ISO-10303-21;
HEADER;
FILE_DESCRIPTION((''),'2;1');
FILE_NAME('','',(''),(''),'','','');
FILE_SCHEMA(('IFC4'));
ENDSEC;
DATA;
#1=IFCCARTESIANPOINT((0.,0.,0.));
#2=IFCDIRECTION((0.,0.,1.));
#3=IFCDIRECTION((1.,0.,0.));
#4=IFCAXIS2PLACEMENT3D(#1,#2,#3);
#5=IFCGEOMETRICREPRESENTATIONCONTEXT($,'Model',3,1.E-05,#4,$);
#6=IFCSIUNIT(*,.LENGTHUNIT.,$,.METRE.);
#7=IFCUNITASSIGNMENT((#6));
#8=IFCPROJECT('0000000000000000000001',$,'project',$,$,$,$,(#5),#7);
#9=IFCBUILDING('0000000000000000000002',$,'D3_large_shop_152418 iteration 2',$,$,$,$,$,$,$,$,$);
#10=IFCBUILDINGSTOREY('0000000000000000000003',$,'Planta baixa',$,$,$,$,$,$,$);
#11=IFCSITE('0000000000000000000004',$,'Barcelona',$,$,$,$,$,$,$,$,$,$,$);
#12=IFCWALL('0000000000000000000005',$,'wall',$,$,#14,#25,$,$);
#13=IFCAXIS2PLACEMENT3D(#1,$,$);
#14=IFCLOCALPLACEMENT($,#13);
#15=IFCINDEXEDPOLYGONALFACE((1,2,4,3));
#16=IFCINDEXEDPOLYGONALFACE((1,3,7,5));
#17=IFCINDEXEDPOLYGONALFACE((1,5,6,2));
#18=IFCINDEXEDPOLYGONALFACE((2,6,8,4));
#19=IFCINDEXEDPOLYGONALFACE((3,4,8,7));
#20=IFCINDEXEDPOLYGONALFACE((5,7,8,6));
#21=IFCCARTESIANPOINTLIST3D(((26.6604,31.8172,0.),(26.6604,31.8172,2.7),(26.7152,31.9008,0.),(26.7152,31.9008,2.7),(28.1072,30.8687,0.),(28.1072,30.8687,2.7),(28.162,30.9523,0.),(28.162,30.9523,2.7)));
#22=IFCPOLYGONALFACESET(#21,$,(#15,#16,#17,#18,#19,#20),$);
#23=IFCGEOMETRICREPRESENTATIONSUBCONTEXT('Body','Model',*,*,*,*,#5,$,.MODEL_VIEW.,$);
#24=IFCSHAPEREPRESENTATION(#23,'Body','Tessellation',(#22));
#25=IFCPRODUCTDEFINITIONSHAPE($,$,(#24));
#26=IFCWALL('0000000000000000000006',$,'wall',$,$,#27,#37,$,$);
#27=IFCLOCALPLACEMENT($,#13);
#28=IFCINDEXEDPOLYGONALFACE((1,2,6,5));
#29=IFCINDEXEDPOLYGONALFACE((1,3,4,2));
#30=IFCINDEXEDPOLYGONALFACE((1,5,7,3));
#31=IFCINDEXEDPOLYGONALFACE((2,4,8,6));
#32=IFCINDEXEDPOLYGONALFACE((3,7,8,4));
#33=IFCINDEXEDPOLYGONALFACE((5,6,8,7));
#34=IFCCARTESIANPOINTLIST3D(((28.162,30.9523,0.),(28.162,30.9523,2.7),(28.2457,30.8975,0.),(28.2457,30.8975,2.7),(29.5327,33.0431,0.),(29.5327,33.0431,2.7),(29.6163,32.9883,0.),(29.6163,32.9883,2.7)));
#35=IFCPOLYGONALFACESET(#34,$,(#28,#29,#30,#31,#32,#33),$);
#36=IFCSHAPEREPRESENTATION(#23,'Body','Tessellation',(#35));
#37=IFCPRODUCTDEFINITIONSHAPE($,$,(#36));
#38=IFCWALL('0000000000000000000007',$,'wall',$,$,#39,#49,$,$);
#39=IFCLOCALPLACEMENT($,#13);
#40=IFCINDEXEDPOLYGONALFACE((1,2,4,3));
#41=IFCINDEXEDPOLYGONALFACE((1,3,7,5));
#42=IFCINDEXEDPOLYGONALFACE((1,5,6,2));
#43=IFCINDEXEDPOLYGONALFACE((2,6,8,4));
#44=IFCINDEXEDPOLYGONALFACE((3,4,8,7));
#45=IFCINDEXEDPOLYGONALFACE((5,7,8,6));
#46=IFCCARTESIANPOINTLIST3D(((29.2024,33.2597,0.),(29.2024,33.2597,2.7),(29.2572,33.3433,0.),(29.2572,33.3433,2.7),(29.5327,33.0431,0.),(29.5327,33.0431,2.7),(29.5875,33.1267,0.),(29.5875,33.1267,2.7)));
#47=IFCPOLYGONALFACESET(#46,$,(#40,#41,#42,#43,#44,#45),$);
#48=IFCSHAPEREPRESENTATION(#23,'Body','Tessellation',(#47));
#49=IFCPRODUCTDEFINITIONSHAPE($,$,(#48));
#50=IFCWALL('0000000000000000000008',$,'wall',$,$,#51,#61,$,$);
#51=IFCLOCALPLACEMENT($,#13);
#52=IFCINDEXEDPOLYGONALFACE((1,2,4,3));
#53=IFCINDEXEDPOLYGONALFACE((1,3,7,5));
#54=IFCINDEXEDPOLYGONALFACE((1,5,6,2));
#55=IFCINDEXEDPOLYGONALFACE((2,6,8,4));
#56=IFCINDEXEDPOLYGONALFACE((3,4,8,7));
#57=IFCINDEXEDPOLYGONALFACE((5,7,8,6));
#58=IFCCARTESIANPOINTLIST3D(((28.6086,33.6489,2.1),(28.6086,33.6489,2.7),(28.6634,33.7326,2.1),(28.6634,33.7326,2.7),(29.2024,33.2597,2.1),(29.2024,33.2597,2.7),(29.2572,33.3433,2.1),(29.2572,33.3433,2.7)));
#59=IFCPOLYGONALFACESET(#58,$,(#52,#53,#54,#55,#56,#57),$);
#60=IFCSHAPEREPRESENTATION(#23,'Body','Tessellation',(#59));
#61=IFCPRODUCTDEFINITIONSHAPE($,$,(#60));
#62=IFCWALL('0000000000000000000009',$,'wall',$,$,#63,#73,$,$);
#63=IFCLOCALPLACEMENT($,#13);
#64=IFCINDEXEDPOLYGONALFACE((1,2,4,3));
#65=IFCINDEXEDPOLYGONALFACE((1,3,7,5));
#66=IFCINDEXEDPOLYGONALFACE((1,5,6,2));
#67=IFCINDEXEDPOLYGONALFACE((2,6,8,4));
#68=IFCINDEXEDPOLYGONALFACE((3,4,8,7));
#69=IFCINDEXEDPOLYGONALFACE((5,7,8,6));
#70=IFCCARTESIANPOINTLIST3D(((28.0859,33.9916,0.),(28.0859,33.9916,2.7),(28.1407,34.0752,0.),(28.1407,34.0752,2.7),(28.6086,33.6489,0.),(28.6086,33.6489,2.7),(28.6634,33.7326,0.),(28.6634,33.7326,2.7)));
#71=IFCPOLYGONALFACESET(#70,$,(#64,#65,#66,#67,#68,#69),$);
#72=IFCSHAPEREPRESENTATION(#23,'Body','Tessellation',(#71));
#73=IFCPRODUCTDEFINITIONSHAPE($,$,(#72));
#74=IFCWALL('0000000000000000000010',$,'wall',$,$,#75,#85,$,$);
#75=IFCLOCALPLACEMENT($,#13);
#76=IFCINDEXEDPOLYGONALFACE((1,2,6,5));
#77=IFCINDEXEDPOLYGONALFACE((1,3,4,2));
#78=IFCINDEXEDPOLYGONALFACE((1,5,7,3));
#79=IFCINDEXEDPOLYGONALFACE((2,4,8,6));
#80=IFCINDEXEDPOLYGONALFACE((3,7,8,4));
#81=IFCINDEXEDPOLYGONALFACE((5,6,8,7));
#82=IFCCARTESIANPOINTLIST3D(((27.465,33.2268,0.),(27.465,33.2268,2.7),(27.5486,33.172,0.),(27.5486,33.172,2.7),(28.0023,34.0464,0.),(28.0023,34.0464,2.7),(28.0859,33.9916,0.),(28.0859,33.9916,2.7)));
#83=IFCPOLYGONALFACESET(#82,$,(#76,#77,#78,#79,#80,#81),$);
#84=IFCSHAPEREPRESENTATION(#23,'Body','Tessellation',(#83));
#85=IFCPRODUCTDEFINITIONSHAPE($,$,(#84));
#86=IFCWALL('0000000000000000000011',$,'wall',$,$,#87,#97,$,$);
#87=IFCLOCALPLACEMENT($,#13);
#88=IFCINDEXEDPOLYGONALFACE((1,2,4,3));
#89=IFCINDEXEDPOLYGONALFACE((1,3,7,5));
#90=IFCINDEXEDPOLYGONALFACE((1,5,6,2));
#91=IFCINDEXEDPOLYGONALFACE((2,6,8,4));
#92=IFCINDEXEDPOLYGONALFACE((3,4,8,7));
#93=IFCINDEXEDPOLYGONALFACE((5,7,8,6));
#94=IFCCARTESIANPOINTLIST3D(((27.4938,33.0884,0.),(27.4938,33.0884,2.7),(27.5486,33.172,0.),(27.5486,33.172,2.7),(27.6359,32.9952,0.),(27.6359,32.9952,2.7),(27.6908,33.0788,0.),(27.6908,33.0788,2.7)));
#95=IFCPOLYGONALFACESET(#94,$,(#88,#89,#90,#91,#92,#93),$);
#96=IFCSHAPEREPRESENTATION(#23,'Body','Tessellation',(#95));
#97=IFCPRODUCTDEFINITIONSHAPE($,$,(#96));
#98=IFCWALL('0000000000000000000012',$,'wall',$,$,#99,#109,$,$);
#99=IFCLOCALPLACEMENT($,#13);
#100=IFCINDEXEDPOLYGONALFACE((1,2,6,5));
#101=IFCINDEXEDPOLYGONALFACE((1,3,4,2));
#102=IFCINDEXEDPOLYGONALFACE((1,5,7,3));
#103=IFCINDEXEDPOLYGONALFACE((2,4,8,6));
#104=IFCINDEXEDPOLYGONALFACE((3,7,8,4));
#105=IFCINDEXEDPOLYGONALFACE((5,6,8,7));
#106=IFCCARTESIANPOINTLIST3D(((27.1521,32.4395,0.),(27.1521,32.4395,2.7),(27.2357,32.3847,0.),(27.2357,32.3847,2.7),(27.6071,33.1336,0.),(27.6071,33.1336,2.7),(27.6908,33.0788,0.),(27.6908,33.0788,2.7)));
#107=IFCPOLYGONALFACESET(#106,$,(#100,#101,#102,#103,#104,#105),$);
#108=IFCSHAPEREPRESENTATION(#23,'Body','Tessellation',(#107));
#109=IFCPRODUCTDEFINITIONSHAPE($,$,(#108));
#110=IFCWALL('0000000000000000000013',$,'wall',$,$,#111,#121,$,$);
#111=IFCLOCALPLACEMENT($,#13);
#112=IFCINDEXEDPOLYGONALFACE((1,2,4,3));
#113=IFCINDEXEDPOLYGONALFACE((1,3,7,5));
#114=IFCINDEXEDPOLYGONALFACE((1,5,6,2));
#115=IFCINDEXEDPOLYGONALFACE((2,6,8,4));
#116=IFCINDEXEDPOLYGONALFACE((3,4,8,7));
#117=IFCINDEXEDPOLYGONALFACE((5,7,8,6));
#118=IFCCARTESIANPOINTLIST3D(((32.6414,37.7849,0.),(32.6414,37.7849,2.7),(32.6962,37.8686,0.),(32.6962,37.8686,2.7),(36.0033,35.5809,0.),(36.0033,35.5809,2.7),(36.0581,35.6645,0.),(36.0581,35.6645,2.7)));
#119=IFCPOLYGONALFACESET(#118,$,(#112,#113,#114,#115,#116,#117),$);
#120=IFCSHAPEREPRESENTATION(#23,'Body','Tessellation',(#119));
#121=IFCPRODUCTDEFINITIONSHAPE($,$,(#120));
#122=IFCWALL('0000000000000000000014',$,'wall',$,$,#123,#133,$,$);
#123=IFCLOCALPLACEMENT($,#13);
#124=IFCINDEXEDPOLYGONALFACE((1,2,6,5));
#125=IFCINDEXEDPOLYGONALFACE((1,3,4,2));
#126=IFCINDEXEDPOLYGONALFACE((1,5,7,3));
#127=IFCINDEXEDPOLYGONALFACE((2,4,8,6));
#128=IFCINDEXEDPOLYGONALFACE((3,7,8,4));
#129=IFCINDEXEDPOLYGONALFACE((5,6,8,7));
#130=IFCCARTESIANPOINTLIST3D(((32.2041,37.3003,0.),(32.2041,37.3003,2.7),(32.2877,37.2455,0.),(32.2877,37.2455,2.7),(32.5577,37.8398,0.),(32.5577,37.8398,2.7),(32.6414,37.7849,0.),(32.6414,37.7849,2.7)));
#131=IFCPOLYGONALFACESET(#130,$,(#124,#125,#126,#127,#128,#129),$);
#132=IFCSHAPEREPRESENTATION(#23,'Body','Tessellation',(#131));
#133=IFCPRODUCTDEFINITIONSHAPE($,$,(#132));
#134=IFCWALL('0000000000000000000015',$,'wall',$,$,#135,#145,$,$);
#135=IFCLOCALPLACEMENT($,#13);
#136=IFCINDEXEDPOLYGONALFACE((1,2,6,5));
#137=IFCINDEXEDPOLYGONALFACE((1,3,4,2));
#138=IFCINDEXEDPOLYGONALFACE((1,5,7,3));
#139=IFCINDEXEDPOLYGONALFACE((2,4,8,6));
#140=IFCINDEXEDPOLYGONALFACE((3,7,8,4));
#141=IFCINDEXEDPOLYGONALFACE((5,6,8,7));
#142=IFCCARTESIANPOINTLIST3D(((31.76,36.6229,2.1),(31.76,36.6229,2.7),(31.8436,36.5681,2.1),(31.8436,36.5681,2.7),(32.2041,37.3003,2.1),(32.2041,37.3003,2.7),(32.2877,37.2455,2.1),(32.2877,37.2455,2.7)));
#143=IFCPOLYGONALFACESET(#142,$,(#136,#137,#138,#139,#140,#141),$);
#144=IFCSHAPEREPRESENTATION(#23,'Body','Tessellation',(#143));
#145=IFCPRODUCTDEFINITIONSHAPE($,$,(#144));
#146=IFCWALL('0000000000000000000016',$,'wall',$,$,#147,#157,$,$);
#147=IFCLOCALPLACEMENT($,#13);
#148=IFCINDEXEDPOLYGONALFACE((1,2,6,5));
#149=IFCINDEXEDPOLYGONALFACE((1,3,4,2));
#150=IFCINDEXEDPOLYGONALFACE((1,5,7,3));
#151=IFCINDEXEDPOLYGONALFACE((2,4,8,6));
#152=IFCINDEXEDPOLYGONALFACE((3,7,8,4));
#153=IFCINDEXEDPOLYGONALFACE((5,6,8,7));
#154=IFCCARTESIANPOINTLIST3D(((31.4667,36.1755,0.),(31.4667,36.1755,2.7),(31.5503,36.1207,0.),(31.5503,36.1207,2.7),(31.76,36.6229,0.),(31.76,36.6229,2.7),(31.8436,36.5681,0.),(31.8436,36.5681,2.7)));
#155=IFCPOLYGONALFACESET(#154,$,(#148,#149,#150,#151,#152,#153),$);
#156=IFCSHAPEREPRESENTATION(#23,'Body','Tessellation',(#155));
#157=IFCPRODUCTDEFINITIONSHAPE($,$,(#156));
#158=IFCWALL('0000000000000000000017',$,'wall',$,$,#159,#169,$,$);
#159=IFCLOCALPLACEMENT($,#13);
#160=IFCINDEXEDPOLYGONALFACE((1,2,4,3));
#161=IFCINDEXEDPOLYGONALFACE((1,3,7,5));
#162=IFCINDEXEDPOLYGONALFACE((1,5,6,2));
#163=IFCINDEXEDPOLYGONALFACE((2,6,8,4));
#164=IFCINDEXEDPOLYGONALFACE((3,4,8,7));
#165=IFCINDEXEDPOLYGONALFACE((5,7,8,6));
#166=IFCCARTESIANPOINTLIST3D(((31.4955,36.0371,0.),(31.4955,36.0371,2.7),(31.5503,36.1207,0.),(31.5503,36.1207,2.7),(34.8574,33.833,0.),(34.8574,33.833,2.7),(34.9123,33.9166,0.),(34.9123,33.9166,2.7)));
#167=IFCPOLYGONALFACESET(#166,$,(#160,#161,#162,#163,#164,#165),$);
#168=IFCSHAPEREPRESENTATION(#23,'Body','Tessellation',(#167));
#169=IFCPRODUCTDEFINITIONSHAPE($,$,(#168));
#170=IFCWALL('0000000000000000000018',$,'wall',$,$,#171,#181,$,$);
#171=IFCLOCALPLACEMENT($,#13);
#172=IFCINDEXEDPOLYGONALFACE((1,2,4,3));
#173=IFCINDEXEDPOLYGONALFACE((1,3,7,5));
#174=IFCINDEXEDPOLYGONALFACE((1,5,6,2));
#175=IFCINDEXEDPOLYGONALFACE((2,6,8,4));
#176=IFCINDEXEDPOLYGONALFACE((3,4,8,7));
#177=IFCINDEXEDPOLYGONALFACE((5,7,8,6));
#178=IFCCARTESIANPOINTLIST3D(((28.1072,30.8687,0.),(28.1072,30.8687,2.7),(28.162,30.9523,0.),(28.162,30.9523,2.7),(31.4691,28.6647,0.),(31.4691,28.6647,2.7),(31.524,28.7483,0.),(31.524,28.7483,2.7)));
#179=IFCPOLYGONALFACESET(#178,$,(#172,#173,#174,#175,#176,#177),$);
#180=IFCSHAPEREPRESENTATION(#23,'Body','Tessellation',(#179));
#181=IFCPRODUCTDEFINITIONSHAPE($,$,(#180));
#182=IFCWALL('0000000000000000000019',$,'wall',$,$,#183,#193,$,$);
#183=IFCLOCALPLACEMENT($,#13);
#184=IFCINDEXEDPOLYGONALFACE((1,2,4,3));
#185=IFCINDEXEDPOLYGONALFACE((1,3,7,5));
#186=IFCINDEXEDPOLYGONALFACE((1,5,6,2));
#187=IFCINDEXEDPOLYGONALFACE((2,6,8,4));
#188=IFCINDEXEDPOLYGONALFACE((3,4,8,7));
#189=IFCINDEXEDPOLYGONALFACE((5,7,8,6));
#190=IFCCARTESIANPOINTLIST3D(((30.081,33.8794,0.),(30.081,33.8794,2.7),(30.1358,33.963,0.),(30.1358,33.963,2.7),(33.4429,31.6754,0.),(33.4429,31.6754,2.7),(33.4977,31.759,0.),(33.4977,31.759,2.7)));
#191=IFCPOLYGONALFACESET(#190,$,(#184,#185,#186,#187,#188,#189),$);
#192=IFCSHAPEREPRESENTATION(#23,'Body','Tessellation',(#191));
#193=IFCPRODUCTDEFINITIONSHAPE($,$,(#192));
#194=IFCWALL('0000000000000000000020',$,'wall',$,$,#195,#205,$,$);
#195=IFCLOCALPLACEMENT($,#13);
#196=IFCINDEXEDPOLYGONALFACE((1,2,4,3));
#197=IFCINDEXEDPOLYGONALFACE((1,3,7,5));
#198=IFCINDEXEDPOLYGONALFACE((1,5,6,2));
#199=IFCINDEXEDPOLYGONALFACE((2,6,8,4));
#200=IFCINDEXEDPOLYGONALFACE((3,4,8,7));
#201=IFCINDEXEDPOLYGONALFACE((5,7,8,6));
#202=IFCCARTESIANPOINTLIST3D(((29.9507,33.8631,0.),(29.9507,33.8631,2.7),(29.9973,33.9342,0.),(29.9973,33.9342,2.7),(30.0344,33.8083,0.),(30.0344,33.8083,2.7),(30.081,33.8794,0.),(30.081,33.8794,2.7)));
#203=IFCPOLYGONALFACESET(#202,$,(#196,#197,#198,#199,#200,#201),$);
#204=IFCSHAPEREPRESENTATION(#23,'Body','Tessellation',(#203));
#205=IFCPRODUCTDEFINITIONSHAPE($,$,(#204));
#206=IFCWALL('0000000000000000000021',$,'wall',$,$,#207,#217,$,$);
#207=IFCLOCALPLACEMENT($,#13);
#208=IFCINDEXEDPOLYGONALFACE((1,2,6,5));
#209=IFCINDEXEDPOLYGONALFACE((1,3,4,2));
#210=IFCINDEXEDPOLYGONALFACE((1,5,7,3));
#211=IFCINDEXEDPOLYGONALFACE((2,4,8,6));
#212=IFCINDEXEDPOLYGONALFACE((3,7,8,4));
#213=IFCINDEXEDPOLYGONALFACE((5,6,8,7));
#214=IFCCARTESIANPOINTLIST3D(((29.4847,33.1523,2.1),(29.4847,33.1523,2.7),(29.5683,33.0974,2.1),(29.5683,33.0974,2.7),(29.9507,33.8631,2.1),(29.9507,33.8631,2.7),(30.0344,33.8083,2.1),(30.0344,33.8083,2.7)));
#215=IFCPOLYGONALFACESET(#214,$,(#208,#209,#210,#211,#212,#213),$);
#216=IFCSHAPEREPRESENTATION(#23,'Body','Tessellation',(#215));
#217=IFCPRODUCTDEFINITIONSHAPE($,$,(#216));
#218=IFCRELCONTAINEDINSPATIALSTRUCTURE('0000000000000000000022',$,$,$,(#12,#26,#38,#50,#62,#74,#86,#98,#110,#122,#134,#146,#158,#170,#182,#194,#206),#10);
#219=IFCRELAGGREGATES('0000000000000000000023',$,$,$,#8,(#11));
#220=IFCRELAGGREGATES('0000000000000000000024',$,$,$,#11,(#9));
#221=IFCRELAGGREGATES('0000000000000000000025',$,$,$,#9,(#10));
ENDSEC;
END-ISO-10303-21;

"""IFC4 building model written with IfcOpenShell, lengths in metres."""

from ifc_helpers import new_model, si_unit, frame, origin, origin_with_axes, place, context, subcontext, project, spatial, polyline, outline, extrude, element, save


model = new_model("IFC4")

# Units and contexts
model_context = context("Model", 3, precision=1e-05, world=origin_with_axes())
body_context = subcontext(model_context, "Body", "Model", "MODEL_VIEW")
ifc_project = project(units=[si_unit("LENGTHUNIT", "METRE")], contexts=[model_context])

# Site, building, storey
site = spatial("IfcSite", under=ifc_project, Name="Barcelona")
building = spatial("IfcBuilding", under=site, Name="D3_large_shop_152418 iteration 2")
storey = spatial("IfcBuildingStorey", under=building, Name="Planta baixa")

# Walls
wall_1_placement = place(None, origin_with_axes())
element("IfcWall", 1, at=wall_1_placement, inside=storey, Name="wall", context=body_context, shape_type="SweptSolid", body=[
    extrude(outline(polyline([(26.7152, 31.9008), (28.162, 30.9523), (28.1072, 30.8687), (26.6604, 31.8172), (26.7152, 31.9008)])), origin(), (0.0, 0.0, 1.0), 2.7),
])
wall_2_placement = place(None, origin_with_axes())
element("IfcWall", 2, at=wall_2_placement, inside=storey, Name="wall", context=body_context, shape_type="SweptSolid", body=[
    extrude(outline(polyline([(28.162, 30.9523), (29.5327, 33.0431), (29.6163, 32.9883), (28.2457, 30.8975), (28.162, 30.9523)])), origin(), (0.0, 0.0, 1.0), 2.7),
])
wall_3_placement = place(None, origin_with_axes())
element("IfcWall", 3, at=wall_3_placement, inside=storey, Name="wall", context=body_context, shape_type="SweptSolid", body=[
    extrude(outline(polyline([(29.5327, 33.0431), (29.2024, 33.2597), (29.2572, 33.3433), (29.5875, 33.1267), (29.5327, 33.0431)])), origin(), (0.0, 0.0, 1.0), 2.7),
])
wall_4_placement = place(None, origin_with_axes())
element("IfcWall", 4, at=wall_4_placement, inside=storey, Name="wall", context=body_context, shape_type="SweptSolid", body=[
    extrude(outline(polyline([(29.2024, 33.2597), (28.6086, 33.6489), (28.6634, 33.7326), (29.2572, 33.3433), (29.2024, 33.2597)])), frame((0.0, 0.0, 2.1)), (0.0, 0.0, 1.0), 0.6),
])
wall_5_placement = place(None, origin_with_axes())
element("IfcWall", 5, at=wall_5_placement, inside=storey, Name="wall", context=body_context, shape_type="SweptSolid", body=[
    extrude(outline(polyline([(28.6086, 33.6489), (28.0859, 33.9916), (28.1407, 34.0752), (28.6634, 33.7326), (28.6086, 33.6489)])), origin(), (0.0, 0.0, 1.0), 2.7),
])
wall_6_placement = place(None, origin_with_axes())
element("IfcWall", 6, at=wall_6_placement, inside=storey, Name="wall", context=body_context, shape_type="SweptSolid", body=[
    extrude(outline(polyline([(28.0859, 33.9916), (27.5486, 33.172), (27.465, 33.2268), (28.0023, 34.0464), (28.0859, 33.9916)])), origin(), (0.0, 0.0, 1.0), 2.7),
])
wall_7_placement = place(None, origin_with_axes())
element("IfcWall", 7, at=wall_7_placement, inside=storey, Name="wall", context=body_context, shape_type="SweptSolid", body=[
    extrude(outline(polyline([(27.5486, 33.172), (27.6908, 33.0788), (27.6359, 32.9952), (27.4938, 33.0884), (27.5486, 33.172)])), origin(), (0.0, 0.0, 1.0), 2.7),
])
wall_8_placement = place(None, origin_with_axes())
element("IfcWall", 8, at=wall_8_placement, inside=storey, Name="wall", context=body_context, shape_type="SweptSolid", body=[
    extrude(outline(polyline([(27.6908, 33.0788), (27.2357, 32.3847), (27.1521, 32.4395), (27.6071, 33.1336), (27.6908, 33.0788)])), origin(), (0.0, 0.0, 1.0), 2.7),
])
wall_9_placement = place(None, origin_with_axes())
element("IfcWall", 9, at=wall_9_placement, inside=storey, Name="wall", context=body_context, shape_type="SweptSolid", body=[
    extrude(outline(polyline([(36.0033, 35.5809), (32.6414, 37.7849), (32.6962, 37.8686), (36.0581, 35.6645), (36.0033, 35.5809)])), origin(), (0.0, 0.0, 1.0), 2.7),
])
wall_10_placement = place(None, origin_with_axes())
element("IfcWall", 10, at=wall_10_placement, inside=storey, Name="wall", context=body_context, shape_type="SweptSolid", body=[
    extrude(outline(polyline([(32.6414, 37.7849), (32.2877, 37.2455), (32.2041, 37.3003), (32.5577, 37.8398), (32.6414, 37.7849)])), origin(), (0.0, 0.0, 1.0), 2.7),
])
wall_11_placement = place(None, origin_with_axes())
element("IfcWall", 11, at=wall_11_placement, inside=storey, Name="wall", context=body_context, shape_type="SweptSolid", body=[
    extrude(outline(polyline([(32.2877, 37.2455), (31.8436, 36.5681), (31.76, 36.6229), (32.2041, 37.3003), (32.2877, 37.2455)])), frame((0.0, 0.0, 2.1)), (0.0, 0.0, 1.0), 0.6),
])
wall_12_placement = place(None, origin_with_axes())
element("IfcWall", 12, at=wall_12_placement, inside=storey, Name="wall", context=body_context, shape_type="SweptSolid", body=[
    extrude(outline(polyline([(31.8436, 36.5681), (31.5503, 36.1207), (31.4667, 36.1755), (31.76, 36.6229), (31.8436, 36.5681)])), origin(), (0.0, 0.0, 1.0), 2.7),
])
wall_13_placement = place(None, origin_with_axes())
element("IfcWall", 13, at=wall_13_placement, inside=storey, Name="wall", context=body_context, shape_type="SweptSolid", body=[
    extrude(outline(polyline([(31.5503, 36.1207), (34.9123, 33.9166), (34.8574, 33.833), (31.4955, 36.0371), (31.5503, 36.1207)])), origin(), (0.0, 0.0, 1.0), 2.7),
])
wall_14_placement = place(None, origin_with_axes())
element("IfcWall", 14, at=wall_14_placement, inside=storey, Name="wall", context=body_context, shape_type="SweptSolid", body=[
    extrude(outline(polyline([(28.162, 30.9523), (31.524, 28.7483), (31.4691, 28.6647), (28.1072, 30.8687), (28.162, 30.9523)])), origin(), (0.0, 0.0, 1.0), 2.7),
])
wall_15_placement = place(None, origin_with_axes())
element("IfcWall", 15, at=wall_15_placement, inside=storey, Name="wall", context=body_context, shape_type="SweptSolid", body=[
    extrude(outline(polyline([(33.4429, 31.6754), (30.081, 33.8794), (30.1358, 33.963), (33.4977, 31.759), (33.4429, 31.6754)])), origin(), (0.0, 0.0, 1.0), 2.7),
])
wall_16_placement = place(None, origin_with_axes())
element("IfcWall", 16, at=wall_16_placement, inside=storey, Name="wall", context=body_context, shape_type="SweptSolid", body=[
    extrude(outline(polyline([(30.081, 33.8794), (30.0344, 33.8083), (29.9507, 33.8631), (29.9973, 33.9342), (30.081, 33.8794)])), origin(), (0.0, 0.0, 1.0), 2.7),
])
wall_17_placement = place(None, origin_with_axes())
element("IfcWall", 17, at=wall_17_placement, inside=storey, Name="wall", context=body_context, shape_type="SweptSolid", body=[
    extrude(outline(polyline([(30.0344, 33.8083), (29.5683, 33.0974), (29.4847, 33.1523), (29.9507, 33.8631), (30.0344, 33.8083)])), frame((0.0, 0.0, 2.1)), (0.0, 0.0, 1.0), 0.6),
])

save(model, "model.ifc")
